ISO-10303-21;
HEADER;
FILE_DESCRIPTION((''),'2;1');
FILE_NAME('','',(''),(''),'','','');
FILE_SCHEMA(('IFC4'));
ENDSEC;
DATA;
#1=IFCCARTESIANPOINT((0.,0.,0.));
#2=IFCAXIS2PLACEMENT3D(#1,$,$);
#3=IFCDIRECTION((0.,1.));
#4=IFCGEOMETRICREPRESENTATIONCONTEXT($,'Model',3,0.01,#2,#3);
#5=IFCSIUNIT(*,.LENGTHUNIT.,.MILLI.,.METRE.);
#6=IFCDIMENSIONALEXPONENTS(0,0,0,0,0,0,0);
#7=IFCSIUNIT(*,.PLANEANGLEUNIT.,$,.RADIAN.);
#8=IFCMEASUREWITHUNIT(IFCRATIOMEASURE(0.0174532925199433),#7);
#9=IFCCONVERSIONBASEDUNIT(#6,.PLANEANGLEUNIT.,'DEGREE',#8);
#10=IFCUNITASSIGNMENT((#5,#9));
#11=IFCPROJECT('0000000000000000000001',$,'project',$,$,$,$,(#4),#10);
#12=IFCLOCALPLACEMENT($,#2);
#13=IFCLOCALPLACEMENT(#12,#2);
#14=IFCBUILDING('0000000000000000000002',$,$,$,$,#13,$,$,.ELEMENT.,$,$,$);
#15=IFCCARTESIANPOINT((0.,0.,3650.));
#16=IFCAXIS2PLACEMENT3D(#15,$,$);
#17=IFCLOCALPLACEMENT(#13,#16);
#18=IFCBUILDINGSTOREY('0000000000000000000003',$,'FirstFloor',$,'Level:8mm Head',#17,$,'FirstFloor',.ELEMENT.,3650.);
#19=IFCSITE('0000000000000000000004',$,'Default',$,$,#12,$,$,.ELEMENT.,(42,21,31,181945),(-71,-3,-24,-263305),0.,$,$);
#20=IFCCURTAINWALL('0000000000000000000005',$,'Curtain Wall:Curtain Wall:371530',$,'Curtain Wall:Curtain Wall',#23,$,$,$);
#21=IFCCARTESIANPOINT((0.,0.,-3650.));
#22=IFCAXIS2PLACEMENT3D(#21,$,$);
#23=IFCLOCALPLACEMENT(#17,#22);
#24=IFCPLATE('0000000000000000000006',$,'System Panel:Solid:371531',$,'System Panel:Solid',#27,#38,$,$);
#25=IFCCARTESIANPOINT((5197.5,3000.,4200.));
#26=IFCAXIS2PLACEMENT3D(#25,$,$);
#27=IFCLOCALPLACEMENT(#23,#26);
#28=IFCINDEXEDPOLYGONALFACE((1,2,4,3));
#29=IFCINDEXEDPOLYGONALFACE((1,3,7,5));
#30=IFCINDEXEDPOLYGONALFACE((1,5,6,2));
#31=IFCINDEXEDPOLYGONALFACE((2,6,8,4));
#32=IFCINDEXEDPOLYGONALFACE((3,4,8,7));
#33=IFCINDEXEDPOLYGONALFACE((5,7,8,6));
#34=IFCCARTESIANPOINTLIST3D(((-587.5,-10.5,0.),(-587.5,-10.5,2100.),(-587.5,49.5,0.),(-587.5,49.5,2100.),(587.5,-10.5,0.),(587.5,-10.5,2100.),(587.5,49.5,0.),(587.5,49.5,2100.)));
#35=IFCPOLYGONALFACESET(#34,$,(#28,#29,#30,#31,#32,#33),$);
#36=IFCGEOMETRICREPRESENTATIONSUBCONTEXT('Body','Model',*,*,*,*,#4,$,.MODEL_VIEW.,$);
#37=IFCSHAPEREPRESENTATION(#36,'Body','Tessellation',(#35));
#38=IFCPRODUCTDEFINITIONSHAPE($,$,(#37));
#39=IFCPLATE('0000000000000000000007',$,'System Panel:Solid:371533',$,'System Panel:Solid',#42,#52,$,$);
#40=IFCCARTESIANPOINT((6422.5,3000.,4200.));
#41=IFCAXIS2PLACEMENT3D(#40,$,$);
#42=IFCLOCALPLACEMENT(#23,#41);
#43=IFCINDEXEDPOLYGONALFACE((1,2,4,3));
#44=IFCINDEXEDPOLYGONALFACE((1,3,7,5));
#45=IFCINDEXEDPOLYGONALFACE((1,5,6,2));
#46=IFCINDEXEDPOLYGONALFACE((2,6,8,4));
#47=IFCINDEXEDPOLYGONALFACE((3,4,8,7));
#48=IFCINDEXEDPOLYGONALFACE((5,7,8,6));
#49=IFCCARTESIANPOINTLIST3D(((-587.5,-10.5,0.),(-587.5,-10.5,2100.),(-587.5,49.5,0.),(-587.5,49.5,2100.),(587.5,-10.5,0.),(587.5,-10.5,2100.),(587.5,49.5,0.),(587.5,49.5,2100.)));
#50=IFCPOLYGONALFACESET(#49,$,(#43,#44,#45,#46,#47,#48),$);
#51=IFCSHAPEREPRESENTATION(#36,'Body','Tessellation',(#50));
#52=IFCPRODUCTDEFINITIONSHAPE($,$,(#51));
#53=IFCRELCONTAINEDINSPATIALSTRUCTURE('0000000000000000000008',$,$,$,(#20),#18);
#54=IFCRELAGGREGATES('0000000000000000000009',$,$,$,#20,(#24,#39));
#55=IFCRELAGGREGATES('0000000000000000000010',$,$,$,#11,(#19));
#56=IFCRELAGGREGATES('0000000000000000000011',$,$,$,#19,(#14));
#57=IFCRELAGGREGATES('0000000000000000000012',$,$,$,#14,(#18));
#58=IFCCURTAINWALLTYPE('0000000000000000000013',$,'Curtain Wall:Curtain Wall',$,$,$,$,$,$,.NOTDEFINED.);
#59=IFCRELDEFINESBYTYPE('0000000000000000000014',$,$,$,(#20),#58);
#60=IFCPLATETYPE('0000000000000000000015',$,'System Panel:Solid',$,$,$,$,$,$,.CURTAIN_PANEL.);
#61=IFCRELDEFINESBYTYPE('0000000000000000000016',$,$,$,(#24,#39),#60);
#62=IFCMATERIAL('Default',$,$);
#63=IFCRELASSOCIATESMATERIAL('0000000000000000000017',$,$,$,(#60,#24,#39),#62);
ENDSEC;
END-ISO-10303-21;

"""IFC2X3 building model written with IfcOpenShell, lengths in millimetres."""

from ifc_helpers import new_model, entity, si_unit, converted_unit, direction, frame, origin, origin_2d_with_axis, place, context, subcontext, project, spatial, rectangle, extrude, source, transform, mapped, material, type_object, type_shapes, element, aggregate, save


model = new_model("IFC2X3")

# Units and contexts
model_context = context("Model", 3, precision=0.01, world=origin(), true_north=direction((0.0, 1.0)))
body_context = subcontext(model_context, "Body", "Model", "MODEL_VIEW")
ifc_project = project(units=[si_unit("LENGTHUNIT", "METRE", prefix="MILLI"), converted_unit("PLANEANGLEUNIT", "DEGREE", entity("IfcRatioMeasure", 0.0174532925199433), si_unit("PLANEANGLEUNIT", "RADIAN"), dimensions=[0, 0, 0, 0, 0, 0, 0])], contexts=[model_context])

# Site, building, storey
site_placement = place(None, origin())
site = spatial("IfcSite", under=ifc_project, at=site_placement, Name="Default", CompositionType="ELEMENT", RefLatitude=(42, 21, 31, 181945), RefLongitude=(-71, -3, -24, -263305), RefElevation=0.0)
building_placement = place(site_placement, origin())
building = spatial("IfcBuilding", under=site, at=building_placement, CompositionType="ELEMENT")
storey_placement = place(building_placement, frame((0.0, 0.0, 3650.0)))
storey = spatial("IfcBuildingStorey", under=building, at=storey_placement, Name="FirstFloor", ObjectType="Level:8mm Head", LongName="FirstFloor", CompositionType="ELEMENT", Elevation=3650.0)

# Curtain wall
curtain_wall_type = type_object("IfcCurtainWallType", Name="Curtain Wall:Curtain Wall", PredefinedType="NOTDEFINED")
curtain_wall_placement = place(storey_placement, frame((0.0, 0.0, -3650.0)))
curtain_wall = element("IfcCurtainWall", 1, at=curtain_wall_placement, inside=storey, type_object=curtain_wall_type, Name="Curtain Wall:Curtain Wall:371530", ObjectType="Curtain Wall:Curtain Wall")

# Plates
ifc_material_1 = material(Name="Default")
plate_type = type_object("IfcPlateType", Name="System Panel:Solid", PredefinedType="CURTAIN_PANEL", material=ifc_material_1)
shared_shape_1 = source(origin(), body_context, "Body", "SweptSolid", [
    extrude(rectangle(XDim=60.0, YDim=1175.0, at=origin_2d_with_axis()), frame((0.0, 19.5, 0.0), z_axis=(0.0, 0.0, 1.0), x_axis=(0.0, 1.0, 0.0)), (0.0, 0.0, 1.0), 2100.0),
])
type_shapes(plate_type, [shared_shape_1])
plate_1_placement = place(curtain_wall_placement, frame((5197.5, 3000.0, 4200.0)))
plate_1 = element("IfcPlate", 2, at=plate_1_placement, type_object=plate_type, material=ifc_material_1, Name="System Panel:Solid:371531", ObjectType="System Panel:Solid", context=body_context, shape_type="MappedRepresentation", body=[
    mapped(shared_shape_1, transform((0.0, 0.0, 0.0), scale=1.0)),
])
plate_2_placement = place(curtain_wall_placement, frame((6422.5, 3000.0, 4200.0)))
plate_2 = element("IfcPlate", 3, at=plate_2_placement, type_object=plate_type, material=ifc_material_1, Name="System Panel:Solid:371533", ObjectType="System Panel:Solid", context=body_context, shape_type="MappedRepresentation", body=[
    mapped(shared_shape_1, transform((0.0, 0.0, 0.0), scale=1.0)),
])
aggregate(curtain_wall, [plate_1, plate_2])

save(model, "model.ifc")
